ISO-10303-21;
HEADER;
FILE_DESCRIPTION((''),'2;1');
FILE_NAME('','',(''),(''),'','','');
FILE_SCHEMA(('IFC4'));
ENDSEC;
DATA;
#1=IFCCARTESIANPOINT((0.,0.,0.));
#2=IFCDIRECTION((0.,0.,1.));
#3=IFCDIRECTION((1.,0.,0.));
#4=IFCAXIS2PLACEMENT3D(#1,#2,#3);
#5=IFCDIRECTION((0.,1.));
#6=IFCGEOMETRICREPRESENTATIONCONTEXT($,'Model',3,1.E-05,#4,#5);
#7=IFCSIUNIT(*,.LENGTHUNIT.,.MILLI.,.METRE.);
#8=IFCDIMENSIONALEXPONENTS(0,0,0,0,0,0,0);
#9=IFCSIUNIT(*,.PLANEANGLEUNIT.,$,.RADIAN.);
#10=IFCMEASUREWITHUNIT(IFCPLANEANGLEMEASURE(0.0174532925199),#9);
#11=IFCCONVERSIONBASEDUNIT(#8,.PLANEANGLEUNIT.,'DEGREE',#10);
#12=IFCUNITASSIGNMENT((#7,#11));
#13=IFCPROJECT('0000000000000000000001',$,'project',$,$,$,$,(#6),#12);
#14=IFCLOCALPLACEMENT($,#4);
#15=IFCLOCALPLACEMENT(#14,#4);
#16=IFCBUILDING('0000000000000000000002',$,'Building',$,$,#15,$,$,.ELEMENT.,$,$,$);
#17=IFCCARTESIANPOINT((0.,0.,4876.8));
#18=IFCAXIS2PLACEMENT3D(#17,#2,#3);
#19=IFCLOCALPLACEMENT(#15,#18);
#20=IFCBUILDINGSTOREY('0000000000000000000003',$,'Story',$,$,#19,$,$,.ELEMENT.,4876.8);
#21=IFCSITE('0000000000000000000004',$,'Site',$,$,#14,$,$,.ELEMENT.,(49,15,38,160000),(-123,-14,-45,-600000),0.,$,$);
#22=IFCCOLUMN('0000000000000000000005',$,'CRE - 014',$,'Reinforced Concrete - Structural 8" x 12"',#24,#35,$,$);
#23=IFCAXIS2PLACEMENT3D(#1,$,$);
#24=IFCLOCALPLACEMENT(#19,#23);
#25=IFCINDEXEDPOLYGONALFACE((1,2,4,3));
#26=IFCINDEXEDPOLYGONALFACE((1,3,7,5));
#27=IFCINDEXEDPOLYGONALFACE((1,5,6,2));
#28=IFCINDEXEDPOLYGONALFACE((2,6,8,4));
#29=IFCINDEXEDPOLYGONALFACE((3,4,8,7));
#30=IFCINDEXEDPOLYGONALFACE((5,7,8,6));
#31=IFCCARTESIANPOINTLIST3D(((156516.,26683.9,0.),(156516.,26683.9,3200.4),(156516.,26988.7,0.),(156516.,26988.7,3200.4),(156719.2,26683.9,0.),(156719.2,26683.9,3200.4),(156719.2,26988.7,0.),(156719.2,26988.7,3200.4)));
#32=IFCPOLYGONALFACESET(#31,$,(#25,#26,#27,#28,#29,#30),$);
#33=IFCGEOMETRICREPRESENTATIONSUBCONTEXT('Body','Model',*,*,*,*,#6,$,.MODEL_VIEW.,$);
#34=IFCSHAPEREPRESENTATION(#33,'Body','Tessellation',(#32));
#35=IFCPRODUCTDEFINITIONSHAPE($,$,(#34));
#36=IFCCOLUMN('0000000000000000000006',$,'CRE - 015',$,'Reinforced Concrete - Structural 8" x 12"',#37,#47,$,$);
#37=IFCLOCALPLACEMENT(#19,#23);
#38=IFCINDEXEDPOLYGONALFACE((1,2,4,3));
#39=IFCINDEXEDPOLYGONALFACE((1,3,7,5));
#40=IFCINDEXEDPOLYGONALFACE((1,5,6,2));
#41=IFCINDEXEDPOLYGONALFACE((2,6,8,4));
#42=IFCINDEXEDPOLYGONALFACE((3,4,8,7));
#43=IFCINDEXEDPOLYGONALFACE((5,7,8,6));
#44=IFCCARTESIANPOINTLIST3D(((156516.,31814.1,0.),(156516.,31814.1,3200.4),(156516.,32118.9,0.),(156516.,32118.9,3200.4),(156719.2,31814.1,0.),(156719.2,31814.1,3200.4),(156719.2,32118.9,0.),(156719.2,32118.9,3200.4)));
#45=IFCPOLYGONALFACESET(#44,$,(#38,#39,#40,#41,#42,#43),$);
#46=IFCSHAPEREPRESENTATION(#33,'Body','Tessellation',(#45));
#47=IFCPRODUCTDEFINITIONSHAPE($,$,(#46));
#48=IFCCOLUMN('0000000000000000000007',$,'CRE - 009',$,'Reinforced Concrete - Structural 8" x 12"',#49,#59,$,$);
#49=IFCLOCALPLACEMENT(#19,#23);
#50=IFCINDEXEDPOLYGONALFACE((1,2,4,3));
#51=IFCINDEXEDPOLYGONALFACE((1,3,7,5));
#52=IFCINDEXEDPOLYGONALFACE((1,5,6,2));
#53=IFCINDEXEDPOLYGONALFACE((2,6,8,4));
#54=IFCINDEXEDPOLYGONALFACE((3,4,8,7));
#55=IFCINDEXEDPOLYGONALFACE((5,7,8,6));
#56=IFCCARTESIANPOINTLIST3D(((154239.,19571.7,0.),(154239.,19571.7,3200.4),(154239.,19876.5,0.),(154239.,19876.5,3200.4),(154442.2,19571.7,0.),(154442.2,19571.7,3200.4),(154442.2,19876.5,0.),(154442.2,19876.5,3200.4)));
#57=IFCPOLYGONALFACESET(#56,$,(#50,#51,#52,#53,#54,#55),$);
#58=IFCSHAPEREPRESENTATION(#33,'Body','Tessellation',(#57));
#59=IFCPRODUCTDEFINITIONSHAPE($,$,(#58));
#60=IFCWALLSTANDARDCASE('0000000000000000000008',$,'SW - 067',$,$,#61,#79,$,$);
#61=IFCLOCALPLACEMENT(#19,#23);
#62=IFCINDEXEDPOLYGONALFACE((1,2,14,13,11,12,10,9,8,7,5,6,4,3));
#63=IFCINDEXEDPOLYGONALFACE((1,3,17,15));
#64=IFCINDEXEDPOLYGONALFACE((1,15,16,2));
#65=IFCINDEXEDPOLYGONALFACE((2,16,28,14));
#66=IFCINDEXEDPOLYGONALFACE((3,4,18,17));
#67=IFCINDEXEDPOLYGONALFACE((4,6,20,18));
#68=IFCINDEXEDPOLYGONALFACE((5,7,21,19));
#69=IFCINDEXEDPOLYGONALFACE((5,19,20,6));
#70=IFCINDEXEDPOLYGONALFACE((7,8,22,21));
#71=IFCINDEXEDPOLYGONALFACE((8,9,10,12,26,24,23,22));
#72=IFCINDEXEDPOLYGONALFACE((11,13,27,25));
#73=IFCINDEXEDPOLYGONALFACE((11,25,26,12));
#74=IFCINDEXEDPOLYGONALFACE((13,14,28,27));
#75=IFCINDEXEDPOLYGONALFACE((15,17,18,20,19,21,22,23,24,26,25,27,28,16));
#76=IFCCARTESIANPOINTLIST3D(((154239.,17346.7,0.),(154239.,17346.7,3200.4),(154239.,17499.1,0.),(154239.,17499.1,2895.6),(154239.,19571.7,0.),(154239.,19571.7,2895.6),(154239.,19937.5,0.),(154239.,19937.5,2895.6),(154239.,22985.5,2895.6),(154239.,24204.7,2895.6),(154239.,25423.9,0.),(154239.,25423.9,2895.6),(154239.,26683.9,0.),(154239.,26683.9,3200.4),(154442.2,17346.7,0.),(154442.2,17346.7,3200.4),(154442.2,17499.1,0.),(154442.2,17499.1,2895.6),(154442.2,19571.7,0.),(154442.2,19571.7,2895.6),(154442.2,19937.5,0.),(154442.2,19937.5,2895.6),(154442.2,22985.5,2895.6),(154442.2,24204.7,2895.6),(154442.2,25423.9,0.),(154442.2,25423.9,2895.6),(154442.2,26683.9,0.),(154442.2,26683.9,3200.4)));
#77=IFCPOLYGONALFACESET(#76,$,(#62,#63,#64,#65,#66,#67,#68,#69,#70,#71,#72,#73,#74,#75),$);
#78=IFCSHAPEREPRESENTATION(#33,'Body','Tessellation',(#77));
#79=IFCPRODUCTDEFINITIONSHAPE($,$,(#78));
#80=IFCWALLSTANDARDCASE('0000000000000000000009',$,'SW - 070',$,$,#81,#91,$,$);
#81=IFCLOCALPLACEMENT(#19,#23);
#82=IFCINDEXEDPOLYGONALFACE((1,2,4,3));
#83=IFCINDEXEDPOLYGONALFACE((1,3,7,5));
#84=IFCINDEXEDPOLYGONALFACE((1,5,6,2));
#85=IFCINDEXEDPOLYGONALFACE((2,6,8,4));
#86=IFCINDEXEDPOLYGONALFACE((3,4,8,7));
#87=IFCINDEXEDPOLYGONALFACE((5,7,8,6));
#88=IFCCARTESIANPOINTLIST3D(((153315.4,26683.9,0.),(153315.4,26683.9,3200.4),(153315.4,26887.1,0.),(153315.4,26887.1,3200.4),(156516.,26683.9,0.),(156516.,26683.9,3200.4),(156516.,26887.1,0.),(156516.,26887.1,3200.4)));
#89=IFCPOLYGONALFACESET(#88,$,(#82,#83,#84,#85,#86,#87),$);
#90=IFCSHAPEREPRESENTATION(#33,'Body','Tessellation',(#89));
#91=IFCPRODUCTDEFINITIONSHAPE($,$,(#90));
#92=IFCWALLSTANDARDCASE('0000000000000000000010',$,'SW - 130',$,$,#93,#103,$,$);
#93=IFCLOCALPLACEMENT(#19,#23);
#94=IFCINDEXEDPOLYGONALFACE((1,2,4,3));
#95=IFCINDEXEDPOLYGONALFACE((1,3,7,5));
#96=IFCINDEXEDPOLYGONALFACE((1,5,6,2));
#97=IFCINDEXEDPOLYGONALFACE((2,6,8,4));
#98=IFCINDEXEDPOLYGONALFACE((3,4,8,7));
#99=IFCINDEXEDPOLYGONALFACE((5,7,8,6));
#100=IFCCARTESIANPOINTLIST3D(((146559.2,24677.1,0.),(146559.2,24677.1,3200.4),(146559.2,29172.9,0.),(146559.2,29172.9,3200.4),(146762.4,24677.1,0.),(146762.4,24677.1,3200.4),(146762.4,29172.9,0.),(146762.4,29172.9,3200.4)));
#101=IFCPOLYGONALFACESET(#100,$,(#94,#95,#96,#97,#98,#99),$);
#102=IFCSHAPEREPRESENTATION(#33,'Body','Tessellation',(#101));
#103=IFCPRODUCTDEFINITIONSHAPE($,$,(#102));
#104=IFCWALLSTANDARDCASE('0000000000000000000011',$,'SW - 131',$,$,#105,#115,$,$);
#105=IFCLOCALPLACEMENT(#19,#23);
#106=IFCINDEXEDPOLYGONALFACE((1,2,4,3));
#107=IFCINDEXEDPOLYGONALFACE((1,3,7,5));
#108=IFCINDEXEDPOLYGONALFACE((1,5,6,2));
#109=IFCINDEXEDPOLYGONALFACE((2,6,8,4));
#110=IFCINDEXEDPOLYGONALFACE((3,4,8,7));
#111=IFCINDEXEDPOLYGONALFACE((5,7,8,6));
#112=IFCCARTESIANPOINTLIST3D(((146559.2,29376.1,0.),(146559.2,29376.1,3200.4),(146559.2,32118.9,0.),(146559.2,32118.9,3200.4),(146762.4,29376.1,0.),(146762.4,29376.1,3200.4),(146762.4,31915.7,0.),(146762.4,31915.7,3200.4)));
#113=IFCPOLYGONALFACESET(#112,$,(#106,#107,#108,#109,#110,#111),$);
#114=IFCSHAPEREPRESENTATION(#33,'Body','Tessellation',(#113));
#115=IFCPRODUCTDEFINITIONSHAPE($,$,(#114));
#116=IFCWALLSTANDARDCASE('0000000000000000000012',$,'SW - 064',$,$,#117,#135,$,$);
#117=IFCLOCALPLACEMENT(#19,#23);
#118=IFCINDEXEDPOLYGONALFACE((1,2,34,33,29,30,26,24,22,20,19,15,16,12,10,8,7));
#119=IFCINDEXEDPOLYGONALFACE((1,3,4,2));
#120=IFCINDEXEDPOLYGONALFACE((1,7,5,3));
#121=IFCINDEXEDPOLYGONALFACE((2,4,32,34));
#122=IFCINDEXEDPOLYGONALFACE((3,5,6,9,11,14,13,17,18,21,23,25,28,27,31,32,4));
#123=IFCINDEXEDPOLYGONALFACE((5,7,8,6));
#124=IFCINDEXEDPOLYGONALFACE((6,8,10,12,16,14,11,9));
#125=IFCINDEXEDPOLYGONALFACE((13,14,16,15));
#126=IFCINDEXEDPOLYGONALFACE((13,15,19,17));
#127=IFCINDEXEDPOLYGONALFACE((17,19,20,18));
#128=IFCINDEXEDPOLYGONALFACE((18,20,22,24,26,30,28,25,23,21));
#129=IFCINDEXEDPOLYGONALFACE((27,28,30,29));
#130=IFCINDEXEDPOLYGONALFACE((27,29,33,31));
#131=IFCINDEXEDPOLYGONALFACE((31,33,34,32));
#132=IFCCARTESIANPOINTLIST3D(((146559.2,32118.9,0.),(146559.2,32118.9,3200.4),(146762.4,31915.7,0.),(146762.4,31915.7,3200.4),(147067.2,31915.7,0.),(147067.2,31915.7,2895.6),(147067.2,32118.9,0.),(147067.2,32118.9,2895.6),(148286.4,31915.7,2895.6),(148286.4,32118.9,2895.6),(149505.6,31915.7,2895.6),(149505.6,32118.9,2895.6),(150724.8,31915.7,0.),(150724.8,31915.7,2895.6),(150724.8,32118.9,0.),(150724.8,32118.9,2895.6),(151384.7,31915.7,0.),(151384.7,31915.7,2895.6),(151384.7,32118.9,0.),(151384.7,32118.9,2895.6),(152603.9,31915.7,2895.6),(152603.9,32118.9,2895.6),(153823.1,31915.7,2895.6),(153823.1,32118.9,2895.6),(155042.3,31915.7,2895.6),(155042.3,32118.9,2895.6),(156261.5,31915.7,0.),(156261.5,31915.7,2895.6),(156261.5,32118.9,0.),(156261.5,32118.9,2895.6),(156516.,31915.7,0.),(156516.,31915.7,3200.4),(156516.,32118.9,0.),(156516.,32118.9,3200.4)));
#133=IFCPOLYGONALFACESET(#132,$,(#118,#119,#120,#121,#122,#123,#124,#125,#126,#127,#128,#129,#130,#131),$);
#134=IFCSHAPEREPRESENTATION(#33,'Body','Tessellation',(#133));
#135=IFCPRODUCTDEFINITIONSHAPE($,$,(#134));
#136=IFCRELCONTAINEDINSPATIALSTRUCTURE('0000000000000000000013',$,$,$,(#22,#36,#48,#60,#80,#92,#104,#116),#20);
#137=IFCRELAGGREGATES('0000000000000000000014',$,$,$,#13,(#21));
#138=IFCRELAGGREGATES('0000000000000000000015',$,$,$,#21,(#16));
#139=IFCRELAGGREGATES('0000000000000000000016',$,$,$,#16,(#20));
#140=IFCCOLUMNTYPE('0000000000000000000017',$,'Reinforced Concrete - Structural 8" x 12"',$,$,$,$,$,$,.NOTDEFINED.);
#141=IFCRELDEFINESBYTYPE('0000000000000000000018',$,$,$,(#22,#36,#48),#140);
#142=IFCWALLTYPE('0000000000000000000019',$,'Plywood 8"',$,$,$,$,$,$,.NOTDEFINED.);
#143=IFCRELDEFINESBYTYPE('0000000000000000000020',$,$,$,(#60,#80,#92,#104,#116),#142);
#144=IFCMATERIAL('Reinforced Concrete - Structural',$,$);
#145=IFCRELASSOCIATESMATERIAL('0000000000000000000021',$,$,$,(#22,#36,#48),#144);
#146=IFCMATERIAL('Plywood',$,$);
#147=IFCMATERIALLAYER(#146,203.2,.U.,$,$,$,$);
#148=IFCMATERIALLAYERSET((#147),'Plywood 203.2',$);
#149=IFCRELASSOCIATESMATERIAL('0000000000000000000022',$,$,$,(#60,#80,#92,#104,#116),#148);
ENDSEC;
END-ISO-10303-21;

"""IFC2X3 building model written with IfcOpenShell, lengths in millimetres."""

from ifc_helpers import new_model, entity, si_unit, converted_unit, direction, frame, origin_with_axes, origin_2d_with_axis, place, context, subcontext, project, spatial, polyline, rectangle, outline, extrude, material, layer, layer_set, layer_usage, type_object, element, save


model = new_model("IFC2X3")

# Units and contexts
model_context = context("Model", 3, precision=1e-05, world=origin_with_axes(), true_north=direction((0.0, 1.0)))
body_context = subcontext(model_context, "Body", "Model", "MODEL_VIEW")
ifc_project = project(units=[si_unit("LENGTHUNIT", "METRE", prefix="MILLI"), converted_unit("PLANEANGLEUNIT", "DEGREE", entity("IfcPlaneAngleMeasure", 0.0174532925199), si_unit("PLANEANGLEUNIT", "RADIAN"), dimensions=[0, 0, 0, 0, 0, 0, 0])], contexts=[model_context])

# Site, building, storey
site_placement = place(None, origin_with_axes())
site = spatial("IfcSite", under=ifc_project, at=site_placement, Name="Site", CompositionType="ELEMENT", RefLatitude=(49, 15, 38, 160000), RefLongitude=(-123, -14, -45, -600000), RefElevation=0.0)
building_placement = place(site_placement, origin_with_axes())
building = spatial("IfcBuilding", under=site, at=building_placement, Name="Building", CompositionType="ELEMENT")
storey_placement = place(building_placement, frame((0.0, 0.0, 4876.8), z_axis=(0.0, 0.0, 1.0), x_axis=(1.0, 0.0, 0.0)))
storey = spatial("IfcBuildingStorey", under=building, at=storey_placement, Name="Story", CompositionType="ELEMENT", Elevation=4876.8)

# Columns
ifc_material_1 = material(Name="Reinforced Concrete - Structural")
column_type = type_object("IfcColumnType", Name="Reinforced Concrete - Structural 8\" x 12\"", PredefinedType="NOTDEFINED")
for number, where, z_axis, x_axis, name in (
    (1, (156617.6, 26836.3, 0.0), (0.0, 0.0, 1.0), (1.0, 0.0, 0.0), "CRE - 014"),
    (2, (156617.6, 31966.5, 0.0), (0.0, 0.0, 1.0), (1.0, 0.0, 0.0), "CRE - 015"),
    (3, (154340.6, 19724.1, 0.0), (0.0, 0.0, 1.0), (1.0, 0.0, 0.0), "CRE - 009"),
):
    element("IfcColumn", number, at=place(storey_placement, frame(where, z_axis=z_axis, x_axis=x_axis)), inside=storey, type_object=column_type, material=ifc_material_1, Name=name, ObjectType="Reinforced Concrete - Structural 8\" x 12\"", context=body_context, shape_type="SweptSolid", body=[
        extrude(rectangle(XDim=203.2, YDim=304.8, at=origin_2d_with_axis()), origin_with_axes(), (0.0, 0.0, 1.0), 3200.4),
    ])

# Wall, openings
ifc_material_2 = material(Name="Plywood")
ifc_layer_1 = layer(ifc_material_2, 203.2, ventilated="UNKNOWN")
ifc_layer_set_1 = layer_set([ifc_layer_1], Name="Plywood 203.2")
ifc_layer_usage_1 = layer_usage(ifc_layer_set_1, "AXIS2", "POSITIVE", 0.0)
wall_type_1 = type_object("IfcWallType", Name="Plywood 8\"", PredefinedType="NOTDEFINED")
wall_1_placement = place(storey_placement, frame((154239.0, 26887.1, 0.0), z_axis=(0.0, 0.0, 1.0), x_axis=(0.0, -1.0, 0.0)))
wall_1 = element("IfcWallStandardCase", 4, at=wall_1_placement, inside=storey, type_object=wall_type_1, material=ifc_layer_usage_1, Name="SW - 067", context=body_context, shape_type="SweptSolid", body=[
    extrude(outline(polyline([(203.2, 0.0), (9540.4, 0.0), (9540.4, 203.2), (203.2, 203.2), (203.2, 0.0)])), origin_with_axes(), (0.0, 0.0, 1.0), 3200.4),
])
opening_1_placement = place(wall_1_placement, frame((8351.7, 0.0, 0.0), z_axis=(0.0, 0.0, 1.0), x_axis=(1.0, 0.0, 0.0)))
element("IfcOpeningElement", 5, at=opening_1_placement, cuts=wall_1, context=body_context, shape_type="SweptSolid", body=[
    extrude(rectangle(XDim=2072.6, YDim=2895.6, at=origin_2d_with_axis()), frame((0.0, -203.2, 1447.8), z_axis=(0.0, -1.0, 0.0), x_axis=(-1.0, 0.0, 0.0)), (0.0, 0.0, -1.0), 609.6),
])
opening_2_placement = place(wall_1_placement, frame((2072.8, 0.0, 0.0), z_axis=(0.0, 0.0, 1.0), x_axis=(1.0, 0.0, 0.0)))
element("IfcOpeningElement", 6, at=opening_2_placement, cuts=wall_1, context=body_context, shape_type="SweptSolid", body=[
    extrude(rectangle(XDim=1219.2, YDim=2895.6, at=origin_2d_with_axis()), frame((0.0, -203.2, 1447.8), z_axis=(0.0, 1.0, 0.0), x_axis=(1.0, 0.0, 0.0)), (0.0, 0.0, 1.0), 609.6),
])
opening_3_placement = place(wall_1_placement, frame((3292.0, 0.0, 0.0), z_axis=(0.0, 0.0, 1.0), x_axis=(1.0, 0.0, 0.0)))
element("IfcOpeningElement", 7, at=opening_3_placement, cuts=wall_1, context=body_context, shape_type="SweptSolid", body=[
    extrude(rectangle(XDim=1219.2, YDim=2895.6, at=origin_2d_with_axis()), frame((0.0, -203.2, 1447.8), z_axis=(0.0, -1.0, 0.0), x_axis=(-1.0, 0.0, 0.0)), (0.0, 0.0, -1.0), 609.6),
])
opening_4_placement = place(wall_1_placement, frame((5425.6, 0.0, 0.0), z_axis=(0.0, 0.0, 1.0), x_axis=(1.0, 0.0, 0.0)))
element("IfcOpeningElement", 8, at=opening_4_placement, cuts=wall_1, context=body_context, shape_type="SweptSolid", body=[
    extrude(rectangle(XDim=3048.0, YDim=2895.6, at=origin_2d_with_axis()), frame((0.0, -203.2, 1447.8), z_axis=(0.0, -1.0, 0.0), x_axis=(-1.0, 0.0, 0.0)), (0.0, 0.0, -1.0), 609.6),
])

# Walls
ifc_layer_usage_2 = layer_usage(ifc_layer_set_1, "AXIS2", "NEGATIVE", 0.0)
wall_2_placement = place(storey_placement, frame((153315.4, 26887.1, 0.0), z_axis=(0.0, 0.0, 1.0), x_axis=(1.0, 0.0, 0.0)))
element("IfcWallStandardCase", 9, at=wall_2_placement, inside=storey, type_object=wall_type_1, material=ifc_layer_usage_2, Name="SW - 070", context=body_context, shape_type="SweptSolid", body=[
    extrude(outline(polyline([(0.0, -203.2), (3200.6, -203.2), (3200.6, 0.0), (0.0, 0.0), (0.0, -203.2)])), origin_with_axes(), (0.0, 0.0, 1.0), 3200.4),
])
ifc_layer_usage_3 = layer_usage(ifc_layer_set_1, "AXIS2", "POSITIVE", 0.0)
wall_3_placement = place(storey_placement, frame((146762.4, 24677.1, 0.0), z_axis=(0.0, 0.0, 1.0), x_axis=(0.0, 1.0, 0.0)))
element("IfcWallStandardCase", 10, at=wall_3_placement, inside=storey, type_object=wall_type_1, material=ifc_layer_usage_3, Name="SW - 130", context=body_context, shape_type="SweptSolid", body=[
    extrude(outline(polyline([(0.0, 0.0), (4495.8, 0.0), (4495.8, 203.2), (0.0, 203.2), (0.0, 0.0)])), origin_with_axes(), (0.0, 0.0, 1.0), 3200.4),
])
ifc_layer_usage_4 = layer_usage(ifc_layer_set_1, "AXIS2", "POSITIVE", 0.0)
wall_4_placement = place(storey_placement, frame((146762.4, 29376.1, 0.0), z_axis=(0.0, 0.0, 1.0), x_axis=(0.0, 1.0, 0.0)))
element("IfcWallStandardCase", 11, at=wall_4_placement, inside=storey, type_object=wall_type_1, material=ifc_layer_usage_4, Name="SW - 131", context=body_context, shape_type="SweptSolid", body=[
    extrude(outline(polyline([(0.0, 0.0), (2539.7, 0.0), (2742.9, 203.2), (0.0, 203.2), (0.0, 0.0)])), origin_with_axes(), (0.0, 0.0, 1.0), 3200.4),
])

# Wall, openings
ifc_layer_usage_5 = layer_usage(ifc_layer_set_1, "AXIS2", "NEGATIVE", 0.0)
wall_5_placement = place(storey_placement, frame((156516.0, 31915.7, 0.0), z_axis=(0.0, 0.0, 1.0), x_axis=(-1.0, 0.0, 0.0)))
wall_5 = element("IfcWallStandardCase", 12, at=wall_5_placement, inside=storey, type_object=wall_type_1, material=ifc_layer_usage_5, Name="SW - 064", context=body_context, shape_type="SweptSolid", body=[
    extrude(outline(polyline([(0.0, -203.2), (9956.8, -203.2), (9753.6, 0.0), (0.0, 0.0), (0.0, -203.2)])), origin_with_axes(), (0.0, 0.0, 1.0), 3200.4),
])
opening_5_placement = place(wall_5_placement, frame((864.2, 0.0, 0.0), z_axis=(0.0, 0.0, 1.0), x_axis=(1.0, 0.0, 0.0)))
element("IfcOpeningElement", 13, at=opening_5_placement, cuts=wall_5, context=body_context, shape_type="SweptSolid", body=[
    extrude(rectangle(XDim=1219.2, YDim=2895.6, at=origin_2d_with_axis()), frame((0.0, 203.2, 1447.8), z_axis=(0.0, -1.0, 0.0), x_axis=(-1.0, 0.0, 0.0)), (0.0, 0.0, 1.0), 609.6),
])
opening_6_placement = place(wall_5_placement, frame((2083.4, 0.0, 0.0), z_axis=(0.0, 0.0, 1.0), x_axis=(1.0, 0.0, 0.0)))
element("IfcOpeningElement", 14, at=opening_6_placement, cuts=wall_5, context=body_context, shape_type="SweptSolid", body=[
    extrude(rectangle(XDim=1219.2, YDim=2895.6, at=origin_2d_with_axis()), frame((0.0, 203.2, 1447.8), z_axis=(0.0, 1.0, 0.0), x_axis=(1.0, 0.0, 0.0)), (0.0, 0.0, -1.0), 609.6),
])
opening_7_placement = place(wall_5_placement, frame((3302.6, 0.0, 0.0), z_axis=(0.0, 0.0, 1.0), x_axis=(1.0, 0.0, 0.0)))
element("IfcOpeningElement", 15, at=opening_7_placement, cuts=wall_5, context=body_context, shape_type="SweptSolid", body=[
    extrude(rectangle(XDim=1219.2, YDim=2895.6, at=origin_2d_with_axis()), frame((0.0, 203.2, 1447.8), z_axis=(0.0, 1.0, 0.0), x_axis=(1.0, 0.0, 0.0)), (0.0, 0.0, -1.0), 609.6),
])
opening_8_placement = place(wall_5_placement, frame((4521.8, 0.0, 0.0), z_axis=(0.0, 0.0, 1.0), x_axis=(1.0, 0.0, 0.0)))
element("IfcOpeningElement", 16, at=opening_8_placement, cuts=wall_5, context=body_context, shape_type="SweptSolid", body=[
    extrude(rectangle(XDim=1219.2, YDim=2895.6, at=origin_2d_with_axis()), frame((0.0, 203.2, 1447.8), z_axis=(0.0, -1.0, 0.0), x_axis=(-1.0, 0.0, 0.0)), (0.0, 0.0, 1.0), 609.6),
])
opening_9_placement = place(wall_5_placement, frame((6400.8, 0.0, 0.0), z_axis=(0.0, 0.0, 1.0), x_axis=(1.0, 0.0, 0.0)))
element("IfcOpeningElement", 17, at=opening_9_placement, cuts=wall_5, context=body_context, shape_type="SweptSolid", body=[
    extrude(rectangle(XDim=1219.2, YDim=2895.6, at=origin_2d_with_axis()), frame((0.0, 203.2, 1447.8), z_axis=(0.0, 1.0, 0.0), x_axis=(1.0, 0.0, 0.0)), (0.0, 0.0, -1.0), 609.6),
])
opening_10_placement = place(wall_5_placement, frame((7620.0, 0.0, 0.0), z_axis=(0.0, 0.0, 1.0), x_axis=(1.0, 0.0, 0.0)))
element("IfcOpeningElement", 18, at=opening_10_placement, cuts=wall_5, context=body_context, shape_type="SweptSolid", body=[
    extrude(rectangle(XDim=1219.2, YDim=2895.6, at=origin_2d_with_axis()), frame((0.0, 203.2, 1447.8), z_axis=(0.0, -1.0, 0.0), x_axis=(-1.0, 0.0, 0.0)), (0.0, 0.0, 1.0), 609.6),
])
opening_11_placement = place(wall_5_placement, frame((8839.2, 0.0, 0.0), z_axis=(0.0, 0.0, 1.0), x_axis=(1.0, 0.0, 0.0)))
element("IfcOpeningElement", 19, at=opening_11_placement, cuts=wall_5, context=body_context, shape_type="SweptSolid", body=[
    extrude(rectangle(XDim=1219.2, YDim=2895.6, at=origin_2d_with_axis()), frame((0.0, 203.2, 1447.8), z_axis=(0.0, 1.0, 0.0), x_axis=(1.0, 0.0, 0.0)), (0.0, 0.0, -1.0), 609.6),
])

save(model, "model.ifc")
